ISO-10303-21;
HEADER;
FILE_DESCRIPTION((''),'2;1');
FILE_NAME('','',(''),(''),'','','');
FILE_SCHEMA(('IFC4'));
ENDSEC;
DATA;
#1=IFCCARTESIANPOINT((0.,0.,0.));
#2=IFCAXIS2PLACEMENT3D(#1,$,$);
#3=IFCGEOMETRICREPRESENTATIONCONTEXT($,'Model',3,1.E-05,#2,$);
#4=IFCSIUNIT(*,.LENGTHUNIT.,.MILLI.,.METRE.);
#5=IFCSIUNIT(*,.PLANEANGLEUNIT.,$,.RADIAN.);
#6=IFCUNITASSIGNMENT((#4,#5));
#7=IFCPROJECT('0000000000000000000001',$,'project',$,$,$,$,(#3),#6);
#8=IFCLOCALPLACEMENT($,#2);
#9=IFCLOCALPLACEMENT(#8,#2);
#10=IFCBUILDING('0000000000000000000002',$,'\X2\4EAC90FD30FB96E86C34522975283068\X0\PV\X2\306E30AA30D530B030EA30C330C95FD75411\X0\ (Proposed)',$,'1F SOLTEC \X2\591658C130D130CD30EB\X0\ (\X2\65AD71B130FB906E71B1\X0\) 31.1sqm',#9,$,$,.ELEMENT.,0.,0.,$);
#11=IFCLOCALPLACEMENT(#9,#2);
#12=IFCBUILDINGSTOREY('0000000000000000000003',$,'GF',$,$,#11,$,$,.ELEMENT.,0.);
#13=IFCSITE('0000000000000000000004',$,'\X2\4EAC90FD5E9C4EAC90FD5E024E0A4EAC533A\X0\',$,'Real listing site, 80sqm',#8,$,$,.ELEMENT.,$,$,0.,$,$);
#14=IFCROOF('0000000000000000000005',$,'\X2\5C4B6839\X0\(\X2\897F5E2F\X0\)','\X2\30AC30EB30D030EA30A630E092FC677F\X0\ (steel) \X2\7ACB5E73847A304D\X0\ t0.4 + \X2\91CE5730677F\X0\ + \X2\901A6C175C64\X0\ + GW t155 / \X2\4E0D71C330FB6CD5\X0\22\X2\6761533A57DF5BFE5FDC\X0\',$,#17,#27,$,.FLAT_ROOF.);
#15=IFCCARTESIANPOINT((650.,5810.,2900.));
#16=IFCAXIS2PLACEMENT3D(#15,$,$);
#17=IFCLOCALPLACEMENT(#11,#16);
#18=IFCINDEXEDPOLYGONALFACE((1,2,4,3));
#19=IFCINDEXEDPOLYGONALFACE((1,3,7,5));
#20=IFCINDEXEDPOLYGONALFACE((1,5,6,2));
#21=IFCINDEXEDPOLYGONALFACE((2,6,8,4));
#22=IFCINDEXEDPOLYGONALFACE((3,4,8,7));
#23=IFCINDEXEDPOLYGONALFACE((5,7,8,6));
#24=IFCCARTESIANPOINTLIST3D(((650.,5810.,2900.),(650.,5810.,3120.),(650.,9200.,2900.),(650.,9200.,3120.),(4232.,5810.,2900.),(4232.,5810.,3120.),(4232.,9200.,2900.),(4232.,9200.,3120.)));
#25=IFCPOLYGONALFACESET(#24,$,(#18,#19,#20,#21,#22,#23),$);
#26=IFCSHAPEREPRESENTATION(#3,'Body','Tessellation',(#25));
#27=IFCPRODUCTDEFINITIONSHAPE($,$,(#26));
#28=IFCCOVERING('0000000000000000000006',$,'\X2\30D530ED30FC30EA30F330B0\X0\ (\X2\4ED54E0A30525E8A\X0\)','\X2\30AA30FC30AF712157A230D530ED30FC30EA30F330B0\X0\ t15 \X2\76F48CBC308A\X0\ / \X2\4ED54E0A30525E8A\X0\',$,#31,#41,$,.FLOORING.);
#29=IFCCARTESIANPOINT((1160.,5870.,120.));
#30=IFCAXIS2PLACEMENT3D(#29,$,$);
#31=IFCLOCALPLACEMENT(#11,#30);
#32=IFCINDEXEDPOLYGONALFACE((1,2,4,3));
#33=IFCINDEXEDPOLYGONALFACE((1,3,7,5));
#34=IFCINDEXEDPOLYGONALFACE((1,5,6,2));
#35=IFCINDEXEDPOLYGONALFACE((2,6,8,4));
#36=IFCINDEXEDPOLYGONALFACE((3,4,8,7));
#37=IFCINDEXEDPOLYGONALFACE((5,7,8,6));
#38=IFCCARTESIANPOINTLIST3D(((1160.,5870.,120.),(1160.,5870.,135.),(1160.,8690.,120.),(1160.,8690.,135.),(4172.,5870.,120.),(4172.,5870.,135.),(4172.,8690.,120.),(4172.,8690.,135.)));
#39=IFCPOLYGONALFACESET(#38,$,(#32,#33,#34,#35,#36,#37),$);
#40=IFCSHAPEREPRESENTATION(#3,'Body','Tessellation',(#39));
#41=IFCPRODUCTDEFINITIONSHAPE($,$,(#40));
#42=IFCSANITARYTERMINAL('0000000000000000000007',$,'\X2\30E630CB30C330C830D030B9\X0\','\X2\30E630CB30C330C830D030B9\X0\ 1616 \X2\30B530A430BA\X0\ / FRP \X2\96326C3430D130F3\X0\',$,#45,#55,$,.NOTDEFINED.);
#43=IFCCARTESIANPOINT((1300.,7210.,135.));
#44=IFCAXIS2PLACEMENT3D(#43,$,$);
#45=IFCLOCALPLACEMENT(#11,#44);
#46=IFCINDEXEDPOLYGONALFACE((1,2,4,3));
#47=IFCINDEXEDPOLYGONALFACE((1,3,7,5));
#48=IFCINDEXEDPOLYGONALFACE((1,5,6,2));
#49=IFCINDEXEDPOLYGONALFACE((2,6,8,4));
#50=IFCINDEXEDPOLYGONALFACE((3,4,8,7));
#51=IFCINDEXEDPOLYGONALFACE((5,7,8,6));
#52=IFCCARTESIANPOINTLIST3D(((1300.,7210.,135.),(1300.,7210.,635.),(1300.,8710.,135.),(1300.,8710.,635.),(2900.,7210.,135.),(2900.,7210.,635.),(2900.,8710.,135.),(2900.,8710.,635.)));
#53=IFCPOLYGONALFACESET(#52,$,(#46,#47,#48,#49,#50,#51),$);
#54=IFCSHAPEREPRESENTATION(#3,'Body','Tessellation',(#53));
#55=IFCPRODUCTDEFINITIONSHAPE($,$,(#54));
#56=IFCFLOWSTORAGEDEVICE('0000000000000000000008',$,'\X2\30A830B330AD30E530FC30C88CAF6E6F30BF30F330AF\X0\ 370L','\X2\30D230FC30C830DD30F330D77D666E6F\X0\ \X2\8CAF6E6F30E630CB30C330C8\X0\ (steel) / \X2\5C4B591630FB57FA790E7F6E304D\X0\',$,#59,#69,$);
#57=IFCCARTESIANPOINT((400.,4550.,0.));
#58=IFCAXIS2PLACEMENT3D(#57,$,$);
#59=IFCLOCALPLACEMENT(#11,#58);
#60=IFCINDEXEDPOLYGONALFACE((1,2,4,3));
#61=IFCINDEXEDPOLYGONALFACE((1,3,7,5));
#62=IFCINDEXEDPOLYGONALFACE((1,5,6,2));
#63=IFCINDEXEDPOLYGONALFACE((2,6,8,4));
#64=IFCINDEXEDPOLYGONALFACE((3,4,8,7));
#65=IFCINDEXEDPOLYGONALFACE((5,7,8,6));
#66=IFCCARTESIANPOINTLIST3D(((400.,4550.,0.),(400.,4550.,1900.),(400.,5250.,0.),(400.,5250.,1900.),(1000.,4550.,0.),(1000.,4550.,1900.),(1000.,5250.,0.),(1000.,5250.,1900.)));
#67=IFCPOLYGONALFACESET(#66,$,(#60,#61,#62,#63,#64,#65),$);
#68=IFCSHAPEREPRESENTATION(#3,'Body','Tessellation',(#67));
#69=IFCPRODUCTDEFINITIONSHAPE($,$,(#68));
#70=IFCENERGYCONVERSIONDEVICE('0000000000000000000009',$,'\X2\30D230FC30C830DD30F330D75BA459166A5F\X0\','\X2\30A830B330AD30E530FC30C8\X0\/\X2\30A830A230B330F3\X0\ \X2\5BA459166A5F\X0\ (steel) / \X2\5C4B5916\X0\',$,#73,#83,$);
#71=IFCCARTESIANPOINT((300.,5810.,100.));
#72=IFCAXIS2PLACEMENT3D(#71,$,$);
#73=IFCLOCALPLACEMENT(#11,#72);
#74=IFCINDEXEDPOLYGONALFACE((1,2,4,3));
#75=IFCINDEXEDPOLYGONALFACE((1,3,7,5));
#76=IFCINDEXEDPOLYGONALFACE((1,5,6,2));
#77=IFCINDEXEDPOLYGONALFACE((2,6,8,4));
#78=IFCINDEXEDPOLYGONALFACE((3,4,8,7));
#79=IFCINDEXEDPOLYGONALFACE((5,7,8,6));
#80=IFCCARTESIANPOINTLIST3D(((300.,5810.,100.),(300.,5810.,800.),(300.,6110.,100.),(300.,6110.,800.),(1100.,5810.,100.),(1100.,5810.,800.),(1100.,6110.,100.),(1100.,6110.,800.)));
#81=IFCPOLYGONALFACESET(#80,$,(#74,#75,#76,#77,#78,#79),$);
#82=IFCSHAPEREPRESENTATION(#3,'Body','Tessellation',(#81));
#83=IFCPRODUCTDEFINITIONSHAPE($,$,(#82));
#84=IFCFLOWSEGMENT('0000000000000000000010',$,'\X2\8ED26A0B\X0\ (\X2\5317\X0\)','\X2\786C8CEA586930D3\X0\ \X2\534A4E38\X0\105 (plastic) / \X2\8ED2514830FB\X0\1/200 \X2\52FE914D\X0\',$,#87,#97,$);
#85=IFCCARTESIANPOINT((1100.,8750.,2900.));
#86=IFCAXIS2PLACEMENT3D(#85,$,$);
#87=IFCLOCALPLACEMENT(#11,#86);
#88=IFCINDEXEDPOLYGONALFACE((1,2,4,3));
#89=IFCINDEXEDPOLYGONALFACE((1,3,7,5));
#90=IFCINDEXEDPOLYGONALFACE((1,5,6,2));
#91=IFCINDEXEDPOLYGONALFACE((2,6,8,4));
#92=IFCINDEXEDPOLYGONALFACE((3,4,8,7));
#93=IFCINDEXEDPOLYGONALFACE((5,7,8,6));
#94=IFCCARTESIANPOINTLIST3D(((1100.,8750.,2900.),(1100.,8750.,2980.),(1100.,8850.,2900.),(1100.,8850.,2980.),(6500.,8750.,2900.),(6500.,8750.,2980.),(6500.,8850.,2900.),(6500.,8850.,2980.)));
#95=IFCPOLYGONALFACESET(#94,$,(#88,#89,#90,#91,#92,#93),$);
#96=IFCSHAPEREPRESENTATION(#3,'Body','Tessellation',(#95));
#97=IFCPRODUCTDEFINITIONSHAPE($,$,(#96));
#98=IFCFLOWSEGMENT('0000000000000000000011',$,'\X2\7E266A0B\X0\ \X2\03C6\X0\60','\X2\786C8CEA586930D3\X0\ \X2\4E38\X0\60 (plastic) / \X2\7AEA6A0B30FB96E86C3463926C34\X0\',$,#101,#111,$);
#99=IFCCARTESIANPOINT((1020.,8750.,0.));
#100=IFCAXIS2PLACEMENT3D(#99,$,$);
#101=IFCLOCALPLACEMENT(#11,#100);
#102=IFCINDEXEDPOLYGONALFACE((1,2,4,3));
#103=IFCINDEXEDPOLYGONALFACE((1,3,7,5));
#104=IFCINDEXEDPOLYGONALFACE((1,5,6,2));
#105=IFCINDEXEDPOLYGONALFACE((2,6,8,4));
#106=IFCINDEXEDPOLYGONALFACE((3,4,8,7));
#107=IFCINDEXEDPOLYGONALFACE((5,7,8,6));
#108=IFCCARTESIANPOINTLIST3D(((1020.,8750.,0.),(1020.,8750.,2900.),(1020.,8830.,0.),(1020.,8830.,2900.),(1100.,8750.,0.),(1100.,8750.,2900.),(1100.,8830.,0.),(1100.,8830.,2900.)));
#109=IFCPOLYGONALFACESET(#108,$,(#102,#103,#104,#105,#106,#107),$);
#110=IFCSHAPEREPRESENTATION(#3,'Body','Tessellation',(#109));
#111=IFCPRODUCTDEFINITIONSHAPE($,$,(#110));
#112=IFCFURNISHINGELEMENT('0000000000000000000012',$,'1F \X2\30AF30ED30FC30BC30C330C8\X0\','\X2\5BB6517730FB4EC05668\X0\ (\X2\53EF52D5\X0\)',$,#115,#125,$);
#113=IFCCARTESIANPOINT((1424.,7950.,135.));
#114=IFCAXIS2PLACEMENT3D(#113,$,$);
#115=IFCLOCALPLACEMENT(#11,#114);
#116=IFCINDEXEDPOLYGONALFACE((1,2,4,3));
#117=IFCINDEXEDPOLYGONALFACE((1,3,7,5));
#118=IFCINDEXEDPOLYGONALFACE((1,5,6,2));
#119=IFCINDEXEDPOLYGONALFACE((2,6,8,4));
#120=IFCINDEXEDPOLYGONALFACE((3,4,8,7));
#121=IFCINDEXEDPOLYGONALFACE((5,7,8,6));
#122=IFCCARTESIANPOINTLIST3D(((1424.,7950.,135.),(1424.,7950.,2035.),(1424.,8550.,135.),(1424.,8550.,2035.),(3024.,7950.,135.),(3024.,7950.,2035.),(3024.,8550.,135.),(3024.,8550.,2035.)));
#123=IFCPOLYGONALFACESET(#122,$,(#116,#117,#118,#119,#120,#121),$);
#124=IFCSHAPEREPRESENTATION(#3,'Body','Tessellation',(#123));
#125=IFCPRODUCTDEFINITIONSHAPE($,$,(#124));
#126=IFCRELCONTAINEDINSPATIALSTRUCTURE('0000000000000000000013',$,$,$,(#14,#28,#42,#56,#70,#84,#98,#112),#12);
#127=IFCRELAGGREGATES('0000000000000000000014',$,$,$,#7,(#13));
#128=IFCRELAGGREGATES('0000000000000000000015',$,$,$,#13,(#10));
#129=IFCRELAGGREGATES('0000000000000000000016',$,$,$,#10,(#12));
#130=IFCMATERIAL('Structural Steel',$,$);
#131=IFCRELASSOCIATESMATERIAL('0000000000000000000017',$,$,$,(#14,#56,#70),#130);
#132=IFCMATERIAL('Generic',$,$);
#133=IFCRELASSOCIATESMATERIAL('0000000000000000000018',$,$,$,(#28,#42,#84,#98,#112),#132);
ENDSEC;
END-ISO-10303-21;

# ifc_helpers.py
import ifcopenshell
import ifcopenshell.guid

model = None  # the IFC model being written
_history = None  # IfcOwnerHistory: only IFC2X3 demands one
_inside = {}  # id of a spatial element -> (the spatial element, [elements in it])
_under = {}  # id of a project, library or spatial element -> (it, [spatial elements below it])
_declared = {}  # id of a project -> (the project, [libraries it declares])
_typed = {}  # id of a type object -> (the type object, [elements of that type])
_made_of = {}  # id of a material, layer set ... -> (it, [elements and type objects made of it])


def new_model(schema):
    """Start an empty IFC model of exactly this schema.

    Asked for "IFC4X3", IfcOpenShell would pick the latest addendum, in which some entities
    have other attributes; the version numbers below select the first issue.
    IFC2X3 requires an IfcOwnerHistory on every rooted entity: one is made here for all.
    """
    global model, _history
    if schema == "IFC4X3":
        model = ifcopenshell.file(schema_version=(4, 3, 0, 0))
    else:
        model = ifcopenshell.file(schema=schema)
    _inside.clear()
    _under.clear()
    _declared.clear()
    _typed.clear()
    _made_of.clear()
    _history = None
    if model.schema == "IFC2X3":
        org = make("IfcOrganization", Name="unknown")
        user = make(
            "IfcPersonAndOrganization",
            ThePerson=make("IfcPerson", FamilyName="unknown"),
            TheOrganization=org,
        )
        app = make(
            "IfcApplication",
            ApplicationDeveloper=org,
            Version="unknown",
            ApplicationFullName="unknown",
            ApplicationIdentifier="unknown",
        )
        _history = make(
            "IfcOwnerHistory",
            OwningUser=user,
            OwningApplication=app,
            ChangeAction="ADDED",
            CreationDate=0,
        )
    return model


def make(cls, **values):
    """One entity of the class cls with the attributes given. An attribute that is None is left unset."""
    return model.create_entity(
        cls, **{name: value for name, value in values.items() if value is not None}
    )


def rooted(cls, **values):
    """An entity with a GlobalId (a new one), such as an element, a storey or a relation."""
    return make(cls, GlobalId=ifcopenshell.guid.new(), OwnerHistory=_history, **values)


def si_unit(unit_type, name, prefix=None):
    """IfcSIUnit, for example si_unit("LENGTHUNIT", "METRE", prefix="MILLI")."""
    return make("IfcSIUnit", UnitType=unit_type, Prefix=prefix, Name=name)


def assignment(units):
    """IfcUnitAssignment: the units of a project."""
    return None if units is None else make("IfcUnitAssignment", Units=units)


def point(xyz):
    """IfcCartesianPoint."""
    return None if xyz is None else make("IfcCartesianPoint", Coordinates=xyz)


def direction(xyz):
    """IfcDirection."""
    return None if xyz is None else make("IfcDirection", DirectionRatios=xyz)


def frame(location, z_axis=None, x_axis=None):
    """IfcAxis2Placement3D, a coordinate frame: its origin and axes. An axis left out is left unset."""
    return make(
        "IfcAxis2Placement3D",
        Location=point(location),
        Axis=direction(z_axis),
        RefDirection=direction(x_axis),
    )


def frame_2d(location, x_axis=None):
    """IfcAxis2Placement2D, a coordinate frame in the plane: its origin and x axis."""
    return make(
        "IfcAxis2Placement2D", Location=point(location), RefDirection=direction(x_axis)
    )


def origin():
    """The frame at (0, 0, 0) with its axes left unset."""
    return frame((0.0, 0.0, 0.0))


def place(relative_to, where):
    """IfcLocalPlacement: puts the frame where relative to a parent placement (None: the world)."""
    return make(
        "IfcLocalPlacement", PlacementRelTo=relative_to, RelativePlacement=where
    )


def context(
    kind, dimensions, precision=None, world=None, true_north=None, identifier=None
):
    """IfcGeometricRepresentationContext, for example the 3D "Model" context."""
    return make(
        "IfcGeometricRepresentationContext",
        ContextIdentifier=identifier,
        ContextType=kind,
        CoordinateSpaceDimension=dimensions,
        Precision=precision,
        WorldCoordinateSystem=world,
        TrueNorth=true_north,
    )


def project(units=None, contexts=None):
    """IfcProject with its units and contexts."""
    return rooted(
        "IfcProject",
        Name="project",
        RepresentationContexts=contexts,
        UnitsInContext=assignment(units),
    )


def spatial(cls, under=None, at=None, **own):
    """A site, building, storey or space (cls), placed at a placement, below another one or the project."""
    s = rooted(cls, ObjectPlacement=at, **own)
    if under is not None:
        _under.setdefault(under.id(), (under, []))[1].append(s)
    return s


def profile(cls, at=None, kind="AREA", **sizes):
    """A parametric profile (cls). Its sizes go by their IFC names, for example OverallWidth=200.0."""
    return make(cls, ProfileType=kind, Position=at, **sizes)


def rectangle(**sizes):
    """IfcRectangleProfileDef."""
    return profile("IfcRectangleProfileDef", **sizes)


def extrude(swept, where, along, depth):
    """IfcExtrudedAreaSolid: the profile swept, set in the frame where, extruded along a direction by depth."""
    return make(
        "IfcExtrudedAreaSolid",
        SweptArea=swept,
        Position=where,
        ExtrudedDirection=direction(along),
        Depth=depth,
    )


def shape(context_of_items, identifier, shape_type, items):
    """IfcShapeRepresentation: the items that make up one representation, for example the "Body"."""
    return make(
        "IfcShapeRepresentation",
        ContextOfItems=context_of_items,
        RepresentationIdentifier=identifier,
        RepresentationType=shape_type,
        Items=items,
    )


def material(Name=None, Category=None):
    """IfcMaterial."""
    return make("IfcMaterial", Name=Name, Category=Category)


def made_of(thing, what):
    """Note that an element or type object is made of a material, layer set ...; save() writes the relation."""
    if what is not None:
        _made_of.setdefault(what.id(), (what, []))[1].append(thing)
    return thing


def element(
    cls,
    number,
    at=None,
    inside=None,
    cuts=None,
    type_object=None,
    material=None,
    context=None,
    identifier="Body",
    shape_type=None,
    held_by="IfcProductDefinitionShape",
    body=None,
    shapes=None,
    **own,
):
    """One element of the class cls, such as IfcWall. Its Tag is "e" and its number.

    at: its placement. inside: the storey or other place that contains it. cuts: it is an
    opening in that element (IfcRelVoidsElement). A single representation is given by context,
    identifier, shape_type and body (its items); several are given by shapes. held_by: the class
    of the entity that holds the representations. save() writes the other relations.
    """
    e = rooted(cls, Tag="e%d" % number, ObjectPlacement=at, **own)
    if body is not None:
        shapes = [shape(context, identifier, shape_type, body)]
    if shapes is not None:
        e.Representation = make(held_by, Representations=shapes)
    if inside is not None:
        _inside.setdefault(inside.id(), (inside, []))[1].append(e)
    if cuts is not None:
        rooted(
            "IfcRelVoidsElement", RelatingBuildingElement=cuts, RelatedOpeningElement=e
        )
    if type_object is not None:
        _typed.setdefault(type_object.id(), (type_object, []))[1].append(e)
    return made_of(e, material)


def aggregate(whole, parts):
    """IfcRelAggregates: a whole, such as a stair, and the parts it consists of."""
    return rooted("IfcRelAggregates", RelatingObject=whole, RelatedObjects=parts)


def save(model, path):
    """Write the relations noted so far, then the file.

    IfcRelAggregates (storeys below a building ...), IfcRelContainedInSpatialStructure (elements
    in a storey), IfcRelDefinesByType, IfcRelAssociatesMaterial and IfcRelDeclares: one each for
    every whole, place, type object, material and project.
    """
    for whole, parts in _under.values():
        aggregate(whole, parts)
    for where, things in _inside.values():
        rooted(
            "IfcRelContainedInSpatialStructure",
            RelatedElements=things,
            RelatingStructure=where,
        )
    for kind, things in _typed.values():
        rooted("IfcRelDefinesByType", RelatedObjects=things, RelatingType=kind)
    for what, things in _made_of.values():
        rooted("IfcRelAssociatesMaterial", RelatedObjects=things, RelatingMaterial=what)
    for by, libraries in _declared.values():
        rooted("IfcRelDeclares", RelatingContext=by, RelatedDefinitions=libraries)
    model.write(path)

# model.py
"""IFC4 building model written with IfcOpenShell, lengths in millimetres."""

from ifc_helpers import new_model, si_unit, frame, frame_2d, origin, place, context, project, spatial, rectangle, extrude, material, element, save


model = new_model("IFC4")

# Units and contexts
model_context = context("Model", 3, precision=1e-05, world=origin())
ifc_project = project(units=[si_unit("LENGTHUNIT", "METRE", prefix="MILLI"), si_unit("PLANEANGLEUNIT", "RADIAN")], contexts=[model_context])

# Site, building, storey
site_placement = place(None, origin())
site = spatial("IfcSite", under=ifc_project, at=site_placement, Name="京都府京都市上京区", ObjectType="Real listing site, 80sqm", CompositionType="ELEMENT", RefElevation=0.0)
building_placement = place(site_placement, origin())
building = spatial("IfcBuilding", under=site, at=building_placement, Name="京都・雨水利用とPVのオフグリッド志向 (Proposed)", ObjectType="1F SOLTEC 外壁パネル (断熱・遮熱) 31.1sqm", CompositionType="ELEMENT", ElevationOfRefHeight=0.0, ElevationOfTerrain=0.0)
storey_placement = place(building_placement, origin())
storey = spatial("IfcBuildingStorey", under=building, at=storey_placement, Name="GF", CompositionType="ELEMENT", Elevation=0.0)

# Roof
ifc_material_1 = material(Name="Structural Steel")
roof_placement = place(storey_placement, frame((650.0, 5810.0, 2900.0)))
element("IfcRoof", 1, at=roof_placement, inside=storey, material=ifc_material_1, Name="屋根(西帯)", Description="ガルバリウム鋼板 (steel) 立平葺き t0.4 + 野地板 + 通気層 + GW t155 / 不燃・法22条区域対応", PredefinedType="FLAT_ROOF", context=model_context, shape_type="SweptSolid", body=[
    extrude(rectangle(XDim=3582.0, YDim=3390.0, at=frame_2d((1791.0, 1695.0))), frame((650.0, 5810.0, 2900.0)), (0.0, 0.0, 1.0), 220.0),
])

# Covering
ifc_material_2 = material(Name="Generic")
covering_placement = place(storey_placement, frame((1160.0, 5870.0, 120.0)))
element("IfcCovering", 2, at=covering_placement, inside=storey, material=ifc_material_2, Name="フローリング (仕上げ床)", Description="オーク無垢フローリング t15 直貼り / 仕上げ床", PredefinedType="FLOORING", context=model_context, shape_type="SweptSolid", body=[
    extrude(rectangle(XDim=3012.0, YDim=2820.0, at=frame_2d((1506.0, 1410.0))), frame((1160.0, 5870.0, 120.0)), (0.0, 0.0, 1.0), 15.0),
])

# Sanitary terminal
sanitary_terminal_placement = place(storey_placement, frame((1300.0, 7210.0, 135.0)))
element("IfcSanitaryTerminal", 3, at=sanitary_terminal_placement, inside=storey, material=ifc_material_2, Name="ユニットバス", Description="ユニットバス 1616 サイズ / FRP 防水パン", PredefinedType="NOTDEFINED", context=model_context, shape_type="SweptSolid", body=[
    extrude(rectangle(XDim=1600.0, YDim=1500.0, at=frame_2d((800.0, 750.0))), frame((1300.0, 7210.0, 135.0)), (0.0, 0.0, 1.0), 500.0),
])

# Flow storage device
flow_storage_device_placement = place(storey_placement, frame((400.0, 4550.0, 0.0)))
element("IfcFlowStorageDevice", 4, at=flow_storage_device_placement, inside=storey, material=ifc_material_1, Name="エコキュート貯湯タンク 370L", Description="ヒートポンプ給湯 貯湯ユニット (steel) / 屋外・基礎置き", context=model_context, shape_type="SweptSolid", body=[
    extrude(rectangle(XDim=600.0, YDim=700.0, at=frame_2d((300.0, 350.0))), frame((400.0, 4550.0, 0.0)), (0.0, 0.0, 1.0), 1900.0),
])

# Energy conversion device
energy_conversion_device_placement = place(storey_placement, frame((300.0, 5810.0, 100.0)))
element("IfcEnergyConversionDevice", 5, at=energy_conversion_device_placement, inside=storey, material=ifc_material_1, Name="ヒートポンプ室外機", Description="エコキュート/エアコン 室外機 (steel) / 屋外", context=model_context, shape_type="SweptSolid", body=[
    extrude(rectangle(XDim=800.0, YDim=300.0, at=frame_2d((400.0, 150.0))), frame((300.0, 5810.0, 100.0)), (0.0, 0.0, 1.0), 700.0),
])

# Flow segments
flow_segment_1_placement = place(storey_placement, frame((1100.0, 8750.0, 2900.0)))
element("IfcFlowSegment", 6, at=flow_segment_1_placement, inside=storey, material=ifc_material_2, Name="軒樋 (北)", Description="硬質塩ビ 半丸105 (plastic) / 軒先・1/200 勾配", context=model_context, shape_type="SweptSolid", body=[
    extrude(rectangle(XDim=5400.0, YDim=100.0, at=frame_2d((2700.0, 50.0))), frame((1100.0, 8750.0, 2900.0)), (0.0, 0.0, 1.0), 80.0),
])
flow_segment_2_placement = place(storey_placement, frame((1020.0, 8750.0, 0.0)))
element("IfcFlowSegment", 7, at=flow_segment_2_placement, inside=storey, material=ifc_material_2, Name="縦樋 φ60", Description="硬質塩ビ 丸60 (plastic) / 竪樋・雨水排水", context=model_context, shape_type="SweptSolid", body=[
    extrude(rectangle(XDim=80.0, YDim=80.0, at=frame_2d((40.0, 40.0))), frame((1020.0, 8750.0, 0.0)), (0.0, 0.0, 1.0), 2900.0),
])

# Furnishing element
furnishing_placement = place(storey_placement, frame((1424.0, 7950.0, 135.0)))
element("IfcFurnishingElement", 8, at=furnishing_placement, inside=storey, material=ifc_material_2, Name="1F クローゼット", Description="家具・什器 (可動)", context=model_context, shape_type="SweptSolid", body=[
    extrude(rectangle(XDim=1600.0, YDim=600.0, at=frame_2d((800.0, 300.0))), frame((1424.0, 7950.0, 135.0)), (0.0, 0.0, 1.0), 1900.0),
])

save(model, "model.ifc")
